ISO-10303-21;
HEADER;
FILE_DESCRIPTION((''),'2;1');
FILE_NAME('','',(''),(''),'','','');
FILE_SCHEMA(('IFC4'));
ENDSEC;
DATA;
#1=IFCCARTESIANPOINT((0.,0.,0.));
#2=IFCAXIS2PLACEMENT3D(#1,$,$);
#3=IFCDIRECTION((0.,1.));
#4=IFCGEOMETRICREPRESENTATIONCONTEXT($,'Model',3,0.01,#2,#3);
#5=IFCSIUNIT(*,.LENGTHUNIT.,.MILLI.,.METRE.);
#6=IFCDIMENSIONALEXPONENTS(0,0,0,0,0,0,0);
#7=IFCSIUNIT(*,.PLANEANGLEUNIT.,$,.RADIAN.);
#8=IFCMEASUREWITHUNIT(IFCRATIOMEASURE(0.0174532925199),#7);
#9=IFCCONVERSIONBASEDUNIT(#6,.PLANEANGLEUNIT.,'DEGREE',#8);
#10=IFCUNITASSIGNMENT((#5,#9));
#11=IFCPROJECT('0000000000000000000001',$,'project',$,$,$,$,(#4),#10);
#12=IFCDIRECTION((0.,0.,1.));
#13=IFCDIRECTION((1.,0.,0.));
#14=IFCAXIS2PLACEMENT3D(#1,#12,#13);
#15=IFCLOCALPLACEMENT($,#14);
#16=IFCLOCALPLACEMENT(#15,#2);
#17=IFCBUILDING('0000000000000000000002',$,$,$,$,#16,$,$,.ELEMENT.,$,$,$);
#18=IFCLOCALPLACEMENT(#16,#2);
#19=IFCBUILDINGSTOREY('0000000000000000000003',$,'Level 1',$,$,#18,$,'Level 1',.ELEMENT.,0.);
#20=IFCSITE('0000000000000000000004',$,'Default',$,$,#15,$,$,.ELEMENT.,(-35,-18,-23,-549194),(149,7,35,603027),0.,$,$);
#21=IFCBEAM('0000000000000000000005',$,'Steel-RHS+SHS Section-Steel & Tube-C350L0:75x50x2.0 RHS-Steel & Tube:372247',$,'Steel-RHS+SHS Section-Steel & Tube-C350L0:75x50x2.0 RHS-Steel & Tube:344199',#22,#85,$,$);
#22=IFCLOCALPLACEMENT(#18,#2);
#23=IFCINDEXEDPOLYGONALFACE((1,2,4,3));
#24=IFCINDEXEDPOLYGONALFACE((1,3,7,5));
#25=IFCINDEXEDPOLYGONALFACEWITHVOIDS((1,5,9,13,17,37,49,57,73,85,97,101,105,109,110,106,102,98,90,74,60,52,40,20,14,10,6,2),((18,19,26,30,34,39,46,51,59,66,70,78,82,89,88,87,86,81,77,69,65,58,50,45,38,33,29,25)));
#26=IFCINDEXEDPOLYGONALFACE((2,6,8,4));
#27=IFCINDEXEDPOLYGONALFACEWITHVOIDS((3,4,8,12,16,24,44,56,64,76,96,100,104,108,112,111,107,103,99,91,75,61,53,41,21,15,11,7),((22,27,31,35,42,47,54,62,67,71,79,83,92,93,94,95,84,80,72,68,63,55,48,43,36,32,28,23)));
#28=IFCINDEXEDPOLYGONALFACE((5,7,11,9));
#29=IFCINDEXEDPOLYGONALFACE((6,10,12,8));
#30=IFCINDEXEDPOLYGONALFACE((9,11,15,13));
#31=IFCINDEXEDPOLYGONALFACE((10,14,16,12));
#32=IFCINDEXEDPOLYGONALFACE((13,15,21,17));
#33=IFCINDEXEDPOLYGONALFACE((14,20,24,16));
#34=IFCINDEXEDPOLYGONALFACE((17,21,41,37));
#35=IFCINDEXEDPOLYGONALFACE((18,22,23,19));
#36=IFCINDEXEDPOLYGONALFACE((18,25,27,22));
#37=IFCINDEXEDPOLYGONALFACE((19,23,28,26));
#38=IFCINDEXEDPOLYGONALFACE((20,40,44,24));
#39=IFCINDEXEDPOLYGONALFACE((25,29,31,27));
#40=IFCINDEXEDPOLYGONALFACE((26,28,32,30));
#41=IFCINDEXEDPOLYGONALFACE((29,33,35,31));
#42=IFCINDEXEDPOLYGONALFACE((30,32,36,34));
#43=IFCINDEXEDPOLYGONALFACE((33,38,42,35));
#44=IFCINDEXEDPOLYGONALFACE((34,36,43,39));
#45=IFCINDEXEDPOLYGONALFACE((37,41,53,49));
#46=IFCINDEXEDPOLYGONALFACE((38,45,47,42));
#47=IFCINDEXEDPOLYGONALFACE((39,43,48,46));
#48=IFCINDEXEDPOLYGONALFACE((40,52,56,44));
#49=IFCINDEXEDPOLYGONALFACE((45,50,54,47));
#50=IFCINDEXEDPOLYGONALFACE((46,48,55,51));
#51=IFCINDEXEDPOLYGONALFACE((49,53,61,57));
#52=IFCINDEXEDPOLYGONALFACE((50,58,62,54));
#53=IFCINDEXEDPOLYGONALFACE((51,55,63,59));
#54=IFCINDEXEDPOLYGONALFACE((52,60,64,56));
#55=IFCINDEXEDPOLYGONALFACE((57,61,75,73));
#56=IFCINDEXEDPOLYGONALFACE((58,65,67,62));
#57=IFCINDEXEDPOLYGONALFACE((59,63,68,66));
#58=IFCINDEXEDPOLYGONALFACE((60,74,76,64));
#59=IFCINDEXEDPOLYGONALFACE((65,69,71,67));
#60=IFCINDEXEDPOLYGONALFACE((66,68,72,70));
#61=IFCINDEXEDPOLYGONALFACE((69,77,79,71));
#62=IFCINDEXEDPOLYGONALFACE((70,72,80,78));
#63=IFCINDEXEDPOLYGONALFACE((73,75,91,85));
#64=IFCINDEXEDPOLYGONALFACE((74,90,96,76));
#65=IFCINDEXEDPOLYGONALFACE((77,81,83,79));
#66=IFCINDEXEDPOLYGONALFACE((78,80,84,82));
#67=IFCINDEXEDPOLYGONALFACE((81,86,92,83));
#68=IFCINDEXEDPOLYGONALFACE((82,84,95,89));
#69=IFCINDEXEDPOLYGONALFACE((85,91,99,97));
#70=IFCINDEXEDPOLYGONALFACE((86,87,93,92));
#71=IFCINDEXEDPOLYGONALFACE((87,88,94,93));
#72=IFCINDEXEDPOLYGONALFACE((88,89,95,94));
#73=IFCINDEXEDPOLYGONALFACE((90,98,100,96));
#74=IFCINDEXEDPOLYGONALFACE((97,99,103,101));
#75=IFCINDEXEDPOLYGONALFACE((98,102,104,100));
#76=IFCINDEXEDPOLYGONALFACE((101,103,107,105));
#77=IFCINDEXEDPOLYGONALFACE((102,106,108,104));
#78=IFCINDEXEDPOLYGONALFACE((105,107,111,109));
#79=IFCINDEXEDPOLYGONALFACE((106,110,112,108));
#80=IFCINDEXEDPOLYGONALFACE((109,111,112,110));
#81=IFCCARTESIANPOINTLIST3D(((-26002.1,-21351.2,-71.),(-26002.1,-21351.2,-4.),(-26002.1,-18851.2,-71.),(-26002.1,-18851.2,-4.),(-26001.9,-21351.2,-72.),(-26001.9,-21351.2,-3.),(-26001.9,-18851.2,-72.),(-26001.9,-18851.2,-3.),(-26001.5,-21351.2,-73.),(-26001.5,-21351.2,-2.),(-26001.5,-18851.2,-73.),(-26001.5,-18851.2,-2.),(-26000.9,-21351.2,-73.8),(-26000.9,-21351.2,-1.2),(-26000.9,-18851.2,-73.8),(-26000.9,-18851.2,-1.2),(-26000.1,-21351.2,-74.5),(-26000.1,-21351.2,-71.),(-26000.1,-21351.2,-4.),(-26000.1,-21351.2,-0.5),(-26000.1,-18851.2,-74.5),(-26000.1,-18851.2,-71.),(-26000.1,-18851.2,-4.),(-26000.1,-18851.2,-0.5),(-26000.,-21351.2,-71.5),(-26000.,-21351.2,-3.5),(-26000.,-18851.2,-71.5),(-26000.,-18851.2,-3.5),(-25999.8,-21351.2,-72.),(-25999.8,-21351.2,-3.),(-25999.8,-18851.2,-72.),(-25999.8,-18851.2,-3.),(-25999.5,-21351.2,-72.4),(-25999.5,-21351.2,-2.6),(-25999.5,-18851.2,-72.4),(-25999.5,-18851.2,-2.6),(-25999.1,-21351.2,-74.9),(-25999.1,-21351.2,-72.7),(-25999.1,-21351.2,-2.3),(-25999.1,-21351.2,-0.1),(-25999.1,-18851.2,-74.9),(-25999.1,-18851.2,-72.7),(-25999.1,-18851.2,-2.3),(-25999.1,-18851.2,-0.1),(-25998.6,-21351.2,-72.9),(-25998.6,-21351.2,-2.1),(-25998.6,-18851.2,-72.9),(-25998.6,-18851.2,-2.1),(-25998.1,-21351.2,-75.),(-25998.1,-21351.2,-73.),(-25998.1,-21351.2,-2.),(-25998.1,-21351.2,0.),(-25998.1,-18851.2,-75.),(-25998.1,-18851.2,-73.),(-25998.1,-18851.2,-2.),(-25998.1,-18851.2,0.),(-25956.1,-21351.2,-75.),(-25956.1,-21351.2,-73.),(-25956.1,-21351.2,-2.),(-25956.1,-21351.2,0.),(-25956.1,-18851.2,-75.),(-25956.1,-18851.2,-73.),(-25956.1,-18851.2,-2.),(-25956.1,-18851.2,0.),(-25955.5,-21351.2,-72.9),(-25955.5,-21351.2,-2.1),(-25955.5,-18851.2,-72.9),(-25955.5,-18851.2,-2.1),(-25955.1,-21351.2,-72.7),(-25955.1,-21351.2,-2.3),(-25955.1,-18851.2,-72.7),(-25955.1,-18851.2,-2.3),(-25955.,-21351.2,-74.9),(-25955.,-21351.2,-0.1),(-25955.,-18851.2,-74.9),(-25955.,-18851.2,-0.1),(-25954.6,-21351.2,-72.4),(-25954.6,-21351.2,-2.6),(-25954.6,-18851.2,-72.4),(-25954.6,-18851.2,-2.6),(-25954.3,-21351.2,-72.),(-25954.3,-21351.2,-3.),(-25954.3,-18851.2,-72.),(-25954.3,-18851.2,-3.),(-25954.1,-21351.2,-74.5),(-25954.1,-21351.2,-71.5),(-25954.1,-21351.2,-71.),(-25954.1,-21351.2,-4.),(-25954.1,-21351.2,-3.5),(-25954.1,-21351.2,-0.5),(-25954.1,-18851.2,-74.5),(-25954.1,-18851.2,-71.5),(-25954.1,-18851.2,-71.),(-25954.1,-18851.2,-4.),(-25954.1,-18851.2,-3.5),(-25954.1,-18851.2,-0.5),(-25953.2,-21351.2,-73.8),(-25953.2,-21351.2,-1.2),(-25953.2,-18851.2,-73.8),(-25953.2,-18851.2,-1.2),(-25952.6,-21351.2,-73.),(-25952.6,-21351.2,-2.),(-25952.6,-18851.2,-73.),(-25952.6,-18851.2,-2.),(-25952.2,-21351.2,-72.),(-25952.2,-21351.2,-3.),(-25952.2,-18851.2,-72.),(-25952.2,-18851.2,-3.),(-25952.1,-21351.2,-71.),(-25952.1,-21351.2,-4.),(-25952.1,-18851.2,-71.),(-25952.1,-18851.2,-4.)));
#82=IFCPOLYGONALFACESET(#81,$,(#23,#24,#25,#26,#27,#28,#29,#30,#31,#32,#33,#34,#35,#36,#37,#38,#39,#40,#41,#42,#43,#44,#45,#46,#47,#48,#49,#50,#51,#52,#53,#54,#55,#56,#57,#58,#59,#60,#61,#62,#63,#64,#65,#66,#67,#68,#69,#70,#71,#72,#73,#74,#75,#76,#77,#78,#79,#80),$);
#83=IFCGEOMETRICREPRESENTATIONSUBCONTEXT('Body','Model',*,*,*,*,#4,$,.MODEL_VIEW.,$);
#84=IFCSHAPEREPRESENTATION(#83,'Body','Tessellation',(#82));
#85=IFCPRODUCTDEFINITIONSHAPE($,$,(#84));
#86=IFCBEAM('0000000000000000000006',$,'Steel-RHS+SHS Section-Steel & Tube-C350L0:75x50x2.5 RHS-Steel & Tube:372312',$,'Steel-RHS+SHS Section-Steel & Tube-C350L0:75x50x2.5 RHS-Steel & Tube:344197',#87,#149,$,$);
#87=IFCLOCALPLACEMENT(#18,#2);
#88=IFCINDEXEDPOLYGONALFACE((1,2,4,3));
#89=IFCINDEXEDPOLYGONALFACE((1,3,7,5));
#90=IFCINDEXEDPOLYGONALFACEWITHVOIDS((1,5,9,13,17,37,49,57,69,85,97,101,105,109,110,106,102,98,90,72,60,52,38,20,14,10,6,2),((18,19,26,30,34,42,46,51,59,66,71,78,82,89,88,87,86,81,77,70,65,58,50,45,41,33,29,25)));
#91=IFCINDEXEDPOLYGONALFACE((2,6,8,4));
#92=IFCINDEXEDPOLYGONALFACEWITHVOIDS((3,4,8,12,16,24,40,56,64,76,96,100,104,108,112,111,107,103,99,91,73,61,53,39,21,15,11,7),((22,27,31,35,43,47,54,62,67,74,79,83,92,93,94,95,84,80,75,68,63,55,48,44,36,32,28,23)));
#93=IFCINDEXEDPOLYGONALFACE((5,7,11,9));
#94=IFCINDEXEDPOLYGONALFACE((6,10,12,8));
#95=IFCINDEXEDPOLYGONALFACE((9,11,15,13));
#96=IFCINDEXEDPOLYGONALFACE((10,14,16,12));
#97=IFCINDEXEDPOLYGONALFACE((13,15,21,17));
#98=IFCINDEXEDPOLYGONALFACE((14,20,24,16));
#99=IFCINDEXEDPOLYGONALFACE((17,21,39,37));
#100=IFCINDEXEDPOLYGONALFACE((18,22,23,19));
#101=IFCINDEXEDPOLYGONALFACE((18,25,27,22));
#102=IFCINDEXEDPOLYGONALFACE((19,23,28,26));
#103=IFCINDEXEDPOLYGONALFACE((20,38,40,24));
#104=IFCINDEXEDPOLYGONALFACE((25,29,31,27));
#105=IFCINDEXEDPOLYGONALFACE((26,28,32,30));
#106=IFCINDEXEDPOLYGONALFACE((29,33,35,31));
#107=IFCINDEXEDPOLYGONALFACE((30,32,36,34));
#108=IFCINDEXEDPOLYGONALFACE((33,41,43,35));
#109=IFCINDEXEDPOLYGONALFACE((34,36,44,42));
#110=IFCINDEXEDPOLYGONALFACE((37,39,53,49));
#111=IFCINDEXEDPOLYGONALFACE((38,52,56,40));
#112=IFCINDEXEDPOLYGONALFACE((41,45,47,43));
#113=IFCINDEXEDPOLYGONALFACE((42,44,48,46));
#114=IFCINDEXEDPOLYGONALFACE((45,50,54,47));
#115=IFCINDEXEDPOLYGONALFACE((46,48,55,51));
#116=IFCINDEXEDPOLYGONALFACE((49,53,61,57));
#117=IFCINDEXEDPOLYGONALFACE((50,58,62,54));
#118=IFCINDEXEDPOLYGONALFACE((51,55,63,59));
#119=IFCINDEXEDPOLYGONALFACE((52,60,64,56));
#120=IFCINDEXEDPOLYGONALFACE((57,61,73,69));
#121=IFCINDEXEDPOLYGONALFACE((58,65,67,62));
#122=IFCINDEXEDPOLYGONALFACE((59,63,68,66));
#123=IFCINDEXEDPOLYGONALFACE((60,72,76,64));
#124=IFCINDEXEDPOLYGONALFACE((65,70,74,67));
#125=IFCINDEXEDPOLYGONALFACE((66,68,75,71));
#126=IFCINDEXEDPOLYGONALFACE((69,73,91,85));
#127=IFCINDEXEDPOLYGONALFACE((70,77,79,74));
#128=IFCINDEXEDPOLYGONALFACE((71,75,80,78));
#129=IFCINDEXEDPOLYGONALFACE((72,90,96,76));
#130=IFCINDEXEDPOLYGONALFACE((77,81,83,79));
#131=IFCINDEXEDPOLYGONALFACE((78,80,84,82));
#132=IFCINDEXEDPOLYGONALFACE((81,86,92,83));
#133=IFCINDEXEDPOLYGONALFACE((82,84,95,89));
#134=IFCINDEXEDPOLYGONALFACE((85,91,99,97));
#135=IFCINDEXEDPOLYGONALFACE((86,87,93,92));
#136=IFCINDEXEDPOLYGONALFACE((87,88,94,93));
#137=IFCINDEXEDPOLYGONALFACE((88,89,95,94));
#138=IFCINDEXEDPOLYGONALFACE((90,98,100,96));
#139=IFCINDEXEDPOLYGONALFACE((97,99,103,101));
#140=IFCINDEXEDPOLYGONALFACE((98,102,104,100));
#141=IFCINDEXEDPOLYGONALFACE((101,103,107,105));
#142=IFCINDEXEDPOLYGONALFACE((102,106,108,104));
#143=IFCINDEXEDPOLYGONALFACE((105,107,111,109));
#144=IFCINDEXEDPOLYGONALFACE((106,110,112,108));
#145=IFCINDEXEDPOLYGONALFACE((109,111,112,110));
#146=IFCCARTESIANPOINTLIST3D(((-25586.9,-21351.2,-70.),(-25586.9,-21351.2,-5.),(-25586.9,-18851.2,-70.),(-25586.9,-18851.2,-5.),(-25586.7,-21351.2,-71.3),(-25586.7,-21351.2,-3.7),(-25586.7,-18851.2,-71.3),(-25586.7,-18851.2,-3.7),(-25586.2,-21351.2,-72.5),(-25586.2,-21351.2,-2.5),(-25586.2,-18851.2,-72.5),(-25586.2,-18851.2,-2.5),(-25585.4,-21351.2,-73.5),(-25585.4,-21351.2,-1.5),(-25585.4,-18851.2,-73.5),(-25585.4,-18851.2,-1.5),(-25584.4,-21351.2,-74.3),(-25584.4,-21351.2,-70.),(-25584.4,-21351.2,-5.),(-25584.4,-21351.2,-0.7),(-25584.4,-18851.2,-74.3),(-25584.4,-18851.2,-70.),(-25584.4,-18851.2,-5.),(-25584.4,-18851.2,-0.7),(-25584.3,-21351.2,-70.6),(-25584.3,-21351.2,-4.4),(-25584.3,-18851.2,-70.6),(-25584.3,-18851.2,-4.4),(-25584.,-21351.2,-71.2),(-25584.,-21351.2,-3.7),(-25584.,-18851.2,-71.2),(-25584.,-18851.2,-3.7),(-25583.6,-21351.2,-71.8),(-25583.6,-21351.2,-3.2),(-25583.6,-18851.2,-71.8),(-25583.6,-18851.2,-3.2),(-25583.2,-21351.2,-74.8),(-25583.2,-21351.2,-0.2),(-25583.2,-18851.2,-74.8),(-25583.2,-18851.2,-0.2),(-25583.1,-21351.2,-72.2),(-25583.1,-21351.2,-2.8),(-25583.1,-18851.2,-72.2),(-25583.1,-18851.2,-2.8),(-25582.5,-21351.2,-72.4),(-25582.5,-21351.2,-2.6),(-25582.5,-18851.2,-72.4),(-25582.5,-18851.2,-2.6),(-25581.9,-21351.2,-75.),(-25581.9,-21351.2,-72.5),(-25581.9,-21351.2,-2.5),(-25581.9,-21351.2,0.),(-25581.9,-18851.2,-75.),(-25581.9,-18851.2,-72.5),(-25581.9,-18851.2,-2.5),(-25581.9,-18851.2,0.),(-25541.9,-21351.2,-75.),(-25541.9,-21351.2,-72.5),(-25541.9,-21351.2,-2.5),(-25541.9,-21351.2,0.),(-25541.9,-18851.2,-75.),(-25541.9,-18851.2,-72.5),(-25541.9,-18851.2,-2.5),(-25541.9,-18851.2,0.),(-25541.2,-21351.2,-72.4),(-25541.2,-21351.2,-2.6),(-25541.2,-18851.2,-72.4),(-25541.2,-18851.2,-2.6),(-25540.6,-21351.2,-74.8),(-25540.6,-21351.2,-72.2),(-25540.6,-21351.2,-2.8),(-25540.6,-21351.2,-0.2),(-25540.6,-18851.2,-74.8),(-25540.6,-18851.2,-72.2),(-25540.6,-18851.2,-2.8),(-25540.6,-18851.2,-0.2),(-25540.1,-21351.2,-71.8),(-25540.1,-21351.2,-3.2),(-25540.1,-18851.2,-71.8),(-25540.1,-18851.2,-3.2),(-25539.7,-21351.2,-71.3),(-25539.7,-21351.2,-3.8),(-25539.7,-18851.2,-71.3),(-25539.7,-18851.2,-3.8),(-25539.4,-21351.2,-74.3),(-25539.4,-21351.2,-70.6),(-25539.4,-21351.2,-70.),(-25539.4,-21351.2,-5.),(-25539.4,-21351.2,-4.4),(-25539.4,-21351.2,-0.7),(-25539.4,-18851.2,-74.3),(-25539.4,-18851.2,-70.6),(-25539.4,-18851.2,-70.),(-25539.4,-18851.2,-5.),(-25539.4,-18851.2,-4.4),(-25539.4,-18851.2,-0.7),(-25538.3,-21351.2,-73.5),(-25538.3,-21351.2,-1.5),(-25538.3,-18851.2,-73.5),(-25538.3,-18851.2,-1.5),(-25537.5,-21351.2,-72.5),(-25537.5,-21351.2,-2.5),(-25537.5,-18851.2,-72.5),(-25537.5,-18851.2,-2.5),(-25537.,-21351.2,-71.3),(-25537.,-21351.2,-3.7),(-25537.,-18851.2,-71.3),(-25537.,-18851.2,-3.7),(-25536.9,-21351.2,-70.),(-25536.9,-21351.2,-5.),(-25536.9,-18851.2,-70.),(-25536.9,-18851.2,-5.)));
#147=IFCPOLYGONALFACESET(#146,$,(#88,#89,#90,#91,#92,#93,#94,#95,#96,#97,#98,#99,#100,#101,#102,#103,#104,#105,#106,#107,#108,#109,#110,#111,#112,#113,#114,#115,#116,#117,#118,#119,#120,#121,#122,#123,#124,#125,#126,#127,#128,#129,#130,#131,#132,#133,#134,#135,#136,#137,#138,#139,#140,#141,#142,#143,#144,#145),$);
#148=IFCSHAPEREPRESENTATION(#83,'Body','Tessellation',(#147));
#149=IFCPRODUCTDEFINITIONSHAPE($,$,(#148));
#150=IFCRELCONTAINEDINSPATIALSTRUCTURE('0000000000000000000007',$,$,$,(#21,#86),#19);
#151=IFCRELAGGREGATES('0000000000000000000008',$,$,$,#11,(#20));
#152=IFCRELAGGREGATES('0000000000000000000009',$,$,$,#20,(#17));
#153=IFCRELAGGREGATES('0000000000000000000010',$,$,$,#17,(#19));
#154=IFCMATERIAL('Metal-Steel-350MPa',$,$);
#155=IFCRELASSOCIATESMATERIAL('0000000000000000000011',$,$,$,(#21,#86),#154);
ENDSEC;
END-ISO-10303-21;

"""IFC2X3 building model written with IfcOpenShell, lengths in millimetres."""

from ifc_helpers import new_model, entity, si_unit, converted_unit, direction, frame, frame_2d, origin, origin_with_axes, place, context, subcontext, project, spatial, polyline, circle_curve, parameter, trimmed, segment, composite_curve, outline, extrude, material, element, save


model = new_model("IFC2X3")

# Units and contexts
model_context = context("Model", 3, precision=0.01, world=origin(), true_north=direction((0.0, 1.0)))
body_context = subcontext(model_context, "Body", "Model", "MODEL_VIEW")
ifc_project = project(units=[si_unit("LENGTHUNIT", "METRE", prefix="MILLI"), converted_unit("PLANEANGLEUNIT", "DEGREE", entity("IfcRatioMeasure", 0.0174532925199), si_unit("PLANEANGLEUNIT", "RADIAN"), dimensions=[0, 0, 0, 0, 0, 0, 0])], contexts=[model_context])

# Site, building, storey
site_placement = place(None, origin_with_axes())
site = spatial("IfcSite", under=ifc_project, at=site_placement, Name="Default", CompositionType="ELEMENT", RefLatitude=(-35, -18, -23, -549194), RefLongitude=(149, 7, 35, 603027), RefElevation=0.0)
building_placement = place(site_placement, origin())
building = spatial("IfcBuilding", under=site, at=building_placement, CompositionType="ELEMENT")
storey_placement = place(building_placement, origin())
storey = spatial("IfcBuildingStorey", under=building, at=storey_placement, Name="Level 1", LongName="Level 1", CompositionType="ELEMENT", Elevation=0.0)

# Beams
ifc_material = material(Name="Metal-Steel-350MPa")
beam_1_placement = place(storey_placement, frame((-25977.1, -18851.2, 0.0), z_axis=(0.0, 0.0, 1.0), x_axis=(0.0, -1.0, 0.0)))
element("IfcBeam", 1, at=beam_1_placement, inside=storey, material=ifc_material, Name="Steel-RHS+SHS Section-Steel & Tube-C350L0:75x50x2.0 RHS-Steel & Tube:372247", ObjectType="Steel-RHS+SHS Section-Steel & Tube-C350L0:75x50x2.0 RHS-Steel & Tube:344199", context=body_context, shape_type="SweptSolid", body=[
    extrude(outline(composite_curve([segment(trimmed(circle_curve(frame_2d((-21.0, -33.5), x_axis=(1.0, 0.0)), 4.0), [parameter(180.0)], [parameter(270.0)], True, "PARAMETER"), True, "CONTINUOUS"), segment(polyline([(-21.0, -37.5), (21.0, -37.5)]), True, "CONTINUOUS"), segment(trimmed(circle_curve(frame_2d((21.0, -33.5), x_axis=(1.0, 0.0)), 4.0), [parameter(270.0)], [parameter(0.0)], True, "PARAMETER"), True, "CONTINUOUS"), segment(polyline([(25.0, -33.5), (25.0, 33.5)]), True, "CONTINUOUS"), segment(trimmed(circle_curve(frame_2d((21.0, 33.5), x_axis=(1.0, 0.0)), 4.0), [parameter(0.0)], [parameter(90.0)], True, "PARAMETER"), True, "CONTINUOUS"), segment(polyline([(21.0, 37.5), (-21.0, 37.5)]), True, "CONTINUOUS"), segment(trimmed(circle_curve(frame_2d((-21.0, 33.5), x_axis=(1.0, 0.0)), 4.0), [parameter(90.0)], [parameter(180.0)], True, "PARAMETER"), True, "CONTINUOUS"), segment(polyline([(-25.0, 33.5), (-25.0, -33.5)]), True, "CONTINUOUS")], self_intersect=False), holes=[composite_curve([segment(polyline([(21.0, -35.5), (-21.0, -35.5)]), True, "CONTINUOUS"), segment(trimmed(circle_curve(frame_2d((-21.0, -33.5), x_axis=(1.0, 0.0)), 2.0), [parameter(180.0)], [parameter(270.0)], True, "PARAMETER"), False, "CONTINUOUS"), segment(polyline([(-23.0, -33.5), (-23.0, 33.5)]), True, "CONTINUOUS"), segment(trimmed(circle_curve(frame_2d((-21.0, 33.5), x_axis=(1.0, 0.0)), 2.0), [parameter(90.0)], [parameter(180.0)], True, "PARAMETER"), False, "CONTINUOUS"), segment(polyline([(-21.0, 35.5), (21.0, 35.5)]), True, "CONTINUOUS"), segment(trimmed(circle_curve(frame_2d((21.0, 33.5), x_axis=(1.0, 0.0)), 2.0), [parameter(360.0)], [parameter(90.0)], True, "PARAMETER"), False, "CONTINUOUS"), segment(polyline([(23.0, 33.5), (23.0, -33.5)]), True, "CONTINUOUS"), segment(trimmed(circle_curve(frame_2d((21.0, -33.5), x_axis=(1.0, 0.0)), 2.0), [parameter(270.0)], [parameter(0.0)], True, "PARAMETER"), False, "CONTINUOUS")], self_intersect=False)]), frame((0.0, 0.0, -37.5), z_axis=(1.0, 0.0, 0.0), x_axis=(0.0, -1.0, 0.0)), (0.0, 0.0, 1.0), 2500.0),
])
beam_2_placement = place(storey_placement, frame((-25561.9, -18851.2, 0.0), z_axis=(0.0, 0.0, 1.0), x_axis=(0.0, -1.0, 0.0)))
element("IfcBeam", 2, at=beam_2_placement, inside=storey, material=ifc_material, Name="Steel-RHS+SHS Section-Steel & Tube-C350L0:75x50x2.5 RHS-Steel & Tube:372312", ObjectType="Steel-RHS+SHS Section-Steel & Tube-C350L0:75x50x2.5 RHS-Steel & Tube:344197", context=body_context, shape_type="SweptSolid", body=[
    extrude(outline(composite_curve([segment(trimmed(circle_curve(frame_2d((-20.0, -32.5), x_axis=(1.0, 0.0)), 5.0), [parameter(180.0)], [parameter(270.0)], True, "PARAMETER"), True, "CONTINUOUS"), segment(polyline([(-20.0, -37.5), (20.0, -37.5)]), True, "CONTINUOUS"), segment(trimmed(circle_curve(frame_2d((20.0, -32.5), x_axis=(1.0, 0.0)), 5.0), [parameter(270.0)], [parameter(0.0)], True, "PARAMETER"), True, "CONTINUOUS"), segment(polyline([(25.0, -32.5), (25.0, 32.5)]), True, "CONTINUOUS"), segment(trimmed(circle_curve(frame_2d((20.0, 32.5), x_axis=(1.0, 0.0)), 5.0), [parameter(0.0)], [parameter(90.0)], True, "PARAMETER"), True, "CONTINUOUS"), segment(polyline([(20.0, 37.5), (-20.0, 37.5)]), True, "CONTINUOUS"), segment(trimmed(circle_curve(frame_2d((-20.0, 32.5), x_axis=(1.0, 0.0)), 5.0), [parameter(90.0)], [parameter(180.0)], True, "PARAMETER"), True, "CONTINUOUS"), segment(polyline([(-25.0, 32.5), (-25.0, -32.5)]), True, "CONTINUOUS")], self_intersect=False), holes=[composite_curve([segment(polyline([(20.0, -35.0), (-20.0, -35.0)]), True, "CONTINUOUS"), segment(trimmed(circle_curve(frame_2d((-20.0, -32.5), x_axis=(1.0, 0.0)), 2.5), [parameter(180.0)], [parameter(270.0)], True, "PARAMETER"), False, "CONTINUOUS"), segment(polyline([(-22.5, -32.5), (-22.5, 32.5)]), True, "CONTINUOUS"), segment(trimmed(circle_curve(frame_2d((-20.0, 32.5), x_axis=(1.0, 0.0)), 2.5), [parameter(90.0)], [parameter(180.0)], True, "PARAMETER"), False, "CONTINUOUS"), segment(polyline([(-20.0, 35.0), (20.0, 35.0)]), True, "CONTINUOUS"), segment(trimmed(circle_curve(frame_2d((20.0, 32.5), x_axis=(1.0, 0.0)), 2.5), [parameter(360.0)], [parameter(90.0)], True, "PARAMETER"), False, "CONTINUOUS"), segment(polyline([(22.5, 32.5), (22.5, -32.5)]), True, "CONTINUOUS"), segment(trimmed(circle_curve(frame_2d((20.0, -32.5), x_axis=(1.0, 0.0)), 2.5), [parameter(270.0)], [parameter(360.0)], True, "PARAMETER"), False, "CONTINUOUS")], self_intersect=False)]), frame((0.0, 0.0, -37.5), z_axis=(1.0, 0.0, 0.0), x_axis=(0.0, -1.0, 0.0)), (0.0, 0.0, 1.0), 2500.0),
])

save(model, "model.ifc")
